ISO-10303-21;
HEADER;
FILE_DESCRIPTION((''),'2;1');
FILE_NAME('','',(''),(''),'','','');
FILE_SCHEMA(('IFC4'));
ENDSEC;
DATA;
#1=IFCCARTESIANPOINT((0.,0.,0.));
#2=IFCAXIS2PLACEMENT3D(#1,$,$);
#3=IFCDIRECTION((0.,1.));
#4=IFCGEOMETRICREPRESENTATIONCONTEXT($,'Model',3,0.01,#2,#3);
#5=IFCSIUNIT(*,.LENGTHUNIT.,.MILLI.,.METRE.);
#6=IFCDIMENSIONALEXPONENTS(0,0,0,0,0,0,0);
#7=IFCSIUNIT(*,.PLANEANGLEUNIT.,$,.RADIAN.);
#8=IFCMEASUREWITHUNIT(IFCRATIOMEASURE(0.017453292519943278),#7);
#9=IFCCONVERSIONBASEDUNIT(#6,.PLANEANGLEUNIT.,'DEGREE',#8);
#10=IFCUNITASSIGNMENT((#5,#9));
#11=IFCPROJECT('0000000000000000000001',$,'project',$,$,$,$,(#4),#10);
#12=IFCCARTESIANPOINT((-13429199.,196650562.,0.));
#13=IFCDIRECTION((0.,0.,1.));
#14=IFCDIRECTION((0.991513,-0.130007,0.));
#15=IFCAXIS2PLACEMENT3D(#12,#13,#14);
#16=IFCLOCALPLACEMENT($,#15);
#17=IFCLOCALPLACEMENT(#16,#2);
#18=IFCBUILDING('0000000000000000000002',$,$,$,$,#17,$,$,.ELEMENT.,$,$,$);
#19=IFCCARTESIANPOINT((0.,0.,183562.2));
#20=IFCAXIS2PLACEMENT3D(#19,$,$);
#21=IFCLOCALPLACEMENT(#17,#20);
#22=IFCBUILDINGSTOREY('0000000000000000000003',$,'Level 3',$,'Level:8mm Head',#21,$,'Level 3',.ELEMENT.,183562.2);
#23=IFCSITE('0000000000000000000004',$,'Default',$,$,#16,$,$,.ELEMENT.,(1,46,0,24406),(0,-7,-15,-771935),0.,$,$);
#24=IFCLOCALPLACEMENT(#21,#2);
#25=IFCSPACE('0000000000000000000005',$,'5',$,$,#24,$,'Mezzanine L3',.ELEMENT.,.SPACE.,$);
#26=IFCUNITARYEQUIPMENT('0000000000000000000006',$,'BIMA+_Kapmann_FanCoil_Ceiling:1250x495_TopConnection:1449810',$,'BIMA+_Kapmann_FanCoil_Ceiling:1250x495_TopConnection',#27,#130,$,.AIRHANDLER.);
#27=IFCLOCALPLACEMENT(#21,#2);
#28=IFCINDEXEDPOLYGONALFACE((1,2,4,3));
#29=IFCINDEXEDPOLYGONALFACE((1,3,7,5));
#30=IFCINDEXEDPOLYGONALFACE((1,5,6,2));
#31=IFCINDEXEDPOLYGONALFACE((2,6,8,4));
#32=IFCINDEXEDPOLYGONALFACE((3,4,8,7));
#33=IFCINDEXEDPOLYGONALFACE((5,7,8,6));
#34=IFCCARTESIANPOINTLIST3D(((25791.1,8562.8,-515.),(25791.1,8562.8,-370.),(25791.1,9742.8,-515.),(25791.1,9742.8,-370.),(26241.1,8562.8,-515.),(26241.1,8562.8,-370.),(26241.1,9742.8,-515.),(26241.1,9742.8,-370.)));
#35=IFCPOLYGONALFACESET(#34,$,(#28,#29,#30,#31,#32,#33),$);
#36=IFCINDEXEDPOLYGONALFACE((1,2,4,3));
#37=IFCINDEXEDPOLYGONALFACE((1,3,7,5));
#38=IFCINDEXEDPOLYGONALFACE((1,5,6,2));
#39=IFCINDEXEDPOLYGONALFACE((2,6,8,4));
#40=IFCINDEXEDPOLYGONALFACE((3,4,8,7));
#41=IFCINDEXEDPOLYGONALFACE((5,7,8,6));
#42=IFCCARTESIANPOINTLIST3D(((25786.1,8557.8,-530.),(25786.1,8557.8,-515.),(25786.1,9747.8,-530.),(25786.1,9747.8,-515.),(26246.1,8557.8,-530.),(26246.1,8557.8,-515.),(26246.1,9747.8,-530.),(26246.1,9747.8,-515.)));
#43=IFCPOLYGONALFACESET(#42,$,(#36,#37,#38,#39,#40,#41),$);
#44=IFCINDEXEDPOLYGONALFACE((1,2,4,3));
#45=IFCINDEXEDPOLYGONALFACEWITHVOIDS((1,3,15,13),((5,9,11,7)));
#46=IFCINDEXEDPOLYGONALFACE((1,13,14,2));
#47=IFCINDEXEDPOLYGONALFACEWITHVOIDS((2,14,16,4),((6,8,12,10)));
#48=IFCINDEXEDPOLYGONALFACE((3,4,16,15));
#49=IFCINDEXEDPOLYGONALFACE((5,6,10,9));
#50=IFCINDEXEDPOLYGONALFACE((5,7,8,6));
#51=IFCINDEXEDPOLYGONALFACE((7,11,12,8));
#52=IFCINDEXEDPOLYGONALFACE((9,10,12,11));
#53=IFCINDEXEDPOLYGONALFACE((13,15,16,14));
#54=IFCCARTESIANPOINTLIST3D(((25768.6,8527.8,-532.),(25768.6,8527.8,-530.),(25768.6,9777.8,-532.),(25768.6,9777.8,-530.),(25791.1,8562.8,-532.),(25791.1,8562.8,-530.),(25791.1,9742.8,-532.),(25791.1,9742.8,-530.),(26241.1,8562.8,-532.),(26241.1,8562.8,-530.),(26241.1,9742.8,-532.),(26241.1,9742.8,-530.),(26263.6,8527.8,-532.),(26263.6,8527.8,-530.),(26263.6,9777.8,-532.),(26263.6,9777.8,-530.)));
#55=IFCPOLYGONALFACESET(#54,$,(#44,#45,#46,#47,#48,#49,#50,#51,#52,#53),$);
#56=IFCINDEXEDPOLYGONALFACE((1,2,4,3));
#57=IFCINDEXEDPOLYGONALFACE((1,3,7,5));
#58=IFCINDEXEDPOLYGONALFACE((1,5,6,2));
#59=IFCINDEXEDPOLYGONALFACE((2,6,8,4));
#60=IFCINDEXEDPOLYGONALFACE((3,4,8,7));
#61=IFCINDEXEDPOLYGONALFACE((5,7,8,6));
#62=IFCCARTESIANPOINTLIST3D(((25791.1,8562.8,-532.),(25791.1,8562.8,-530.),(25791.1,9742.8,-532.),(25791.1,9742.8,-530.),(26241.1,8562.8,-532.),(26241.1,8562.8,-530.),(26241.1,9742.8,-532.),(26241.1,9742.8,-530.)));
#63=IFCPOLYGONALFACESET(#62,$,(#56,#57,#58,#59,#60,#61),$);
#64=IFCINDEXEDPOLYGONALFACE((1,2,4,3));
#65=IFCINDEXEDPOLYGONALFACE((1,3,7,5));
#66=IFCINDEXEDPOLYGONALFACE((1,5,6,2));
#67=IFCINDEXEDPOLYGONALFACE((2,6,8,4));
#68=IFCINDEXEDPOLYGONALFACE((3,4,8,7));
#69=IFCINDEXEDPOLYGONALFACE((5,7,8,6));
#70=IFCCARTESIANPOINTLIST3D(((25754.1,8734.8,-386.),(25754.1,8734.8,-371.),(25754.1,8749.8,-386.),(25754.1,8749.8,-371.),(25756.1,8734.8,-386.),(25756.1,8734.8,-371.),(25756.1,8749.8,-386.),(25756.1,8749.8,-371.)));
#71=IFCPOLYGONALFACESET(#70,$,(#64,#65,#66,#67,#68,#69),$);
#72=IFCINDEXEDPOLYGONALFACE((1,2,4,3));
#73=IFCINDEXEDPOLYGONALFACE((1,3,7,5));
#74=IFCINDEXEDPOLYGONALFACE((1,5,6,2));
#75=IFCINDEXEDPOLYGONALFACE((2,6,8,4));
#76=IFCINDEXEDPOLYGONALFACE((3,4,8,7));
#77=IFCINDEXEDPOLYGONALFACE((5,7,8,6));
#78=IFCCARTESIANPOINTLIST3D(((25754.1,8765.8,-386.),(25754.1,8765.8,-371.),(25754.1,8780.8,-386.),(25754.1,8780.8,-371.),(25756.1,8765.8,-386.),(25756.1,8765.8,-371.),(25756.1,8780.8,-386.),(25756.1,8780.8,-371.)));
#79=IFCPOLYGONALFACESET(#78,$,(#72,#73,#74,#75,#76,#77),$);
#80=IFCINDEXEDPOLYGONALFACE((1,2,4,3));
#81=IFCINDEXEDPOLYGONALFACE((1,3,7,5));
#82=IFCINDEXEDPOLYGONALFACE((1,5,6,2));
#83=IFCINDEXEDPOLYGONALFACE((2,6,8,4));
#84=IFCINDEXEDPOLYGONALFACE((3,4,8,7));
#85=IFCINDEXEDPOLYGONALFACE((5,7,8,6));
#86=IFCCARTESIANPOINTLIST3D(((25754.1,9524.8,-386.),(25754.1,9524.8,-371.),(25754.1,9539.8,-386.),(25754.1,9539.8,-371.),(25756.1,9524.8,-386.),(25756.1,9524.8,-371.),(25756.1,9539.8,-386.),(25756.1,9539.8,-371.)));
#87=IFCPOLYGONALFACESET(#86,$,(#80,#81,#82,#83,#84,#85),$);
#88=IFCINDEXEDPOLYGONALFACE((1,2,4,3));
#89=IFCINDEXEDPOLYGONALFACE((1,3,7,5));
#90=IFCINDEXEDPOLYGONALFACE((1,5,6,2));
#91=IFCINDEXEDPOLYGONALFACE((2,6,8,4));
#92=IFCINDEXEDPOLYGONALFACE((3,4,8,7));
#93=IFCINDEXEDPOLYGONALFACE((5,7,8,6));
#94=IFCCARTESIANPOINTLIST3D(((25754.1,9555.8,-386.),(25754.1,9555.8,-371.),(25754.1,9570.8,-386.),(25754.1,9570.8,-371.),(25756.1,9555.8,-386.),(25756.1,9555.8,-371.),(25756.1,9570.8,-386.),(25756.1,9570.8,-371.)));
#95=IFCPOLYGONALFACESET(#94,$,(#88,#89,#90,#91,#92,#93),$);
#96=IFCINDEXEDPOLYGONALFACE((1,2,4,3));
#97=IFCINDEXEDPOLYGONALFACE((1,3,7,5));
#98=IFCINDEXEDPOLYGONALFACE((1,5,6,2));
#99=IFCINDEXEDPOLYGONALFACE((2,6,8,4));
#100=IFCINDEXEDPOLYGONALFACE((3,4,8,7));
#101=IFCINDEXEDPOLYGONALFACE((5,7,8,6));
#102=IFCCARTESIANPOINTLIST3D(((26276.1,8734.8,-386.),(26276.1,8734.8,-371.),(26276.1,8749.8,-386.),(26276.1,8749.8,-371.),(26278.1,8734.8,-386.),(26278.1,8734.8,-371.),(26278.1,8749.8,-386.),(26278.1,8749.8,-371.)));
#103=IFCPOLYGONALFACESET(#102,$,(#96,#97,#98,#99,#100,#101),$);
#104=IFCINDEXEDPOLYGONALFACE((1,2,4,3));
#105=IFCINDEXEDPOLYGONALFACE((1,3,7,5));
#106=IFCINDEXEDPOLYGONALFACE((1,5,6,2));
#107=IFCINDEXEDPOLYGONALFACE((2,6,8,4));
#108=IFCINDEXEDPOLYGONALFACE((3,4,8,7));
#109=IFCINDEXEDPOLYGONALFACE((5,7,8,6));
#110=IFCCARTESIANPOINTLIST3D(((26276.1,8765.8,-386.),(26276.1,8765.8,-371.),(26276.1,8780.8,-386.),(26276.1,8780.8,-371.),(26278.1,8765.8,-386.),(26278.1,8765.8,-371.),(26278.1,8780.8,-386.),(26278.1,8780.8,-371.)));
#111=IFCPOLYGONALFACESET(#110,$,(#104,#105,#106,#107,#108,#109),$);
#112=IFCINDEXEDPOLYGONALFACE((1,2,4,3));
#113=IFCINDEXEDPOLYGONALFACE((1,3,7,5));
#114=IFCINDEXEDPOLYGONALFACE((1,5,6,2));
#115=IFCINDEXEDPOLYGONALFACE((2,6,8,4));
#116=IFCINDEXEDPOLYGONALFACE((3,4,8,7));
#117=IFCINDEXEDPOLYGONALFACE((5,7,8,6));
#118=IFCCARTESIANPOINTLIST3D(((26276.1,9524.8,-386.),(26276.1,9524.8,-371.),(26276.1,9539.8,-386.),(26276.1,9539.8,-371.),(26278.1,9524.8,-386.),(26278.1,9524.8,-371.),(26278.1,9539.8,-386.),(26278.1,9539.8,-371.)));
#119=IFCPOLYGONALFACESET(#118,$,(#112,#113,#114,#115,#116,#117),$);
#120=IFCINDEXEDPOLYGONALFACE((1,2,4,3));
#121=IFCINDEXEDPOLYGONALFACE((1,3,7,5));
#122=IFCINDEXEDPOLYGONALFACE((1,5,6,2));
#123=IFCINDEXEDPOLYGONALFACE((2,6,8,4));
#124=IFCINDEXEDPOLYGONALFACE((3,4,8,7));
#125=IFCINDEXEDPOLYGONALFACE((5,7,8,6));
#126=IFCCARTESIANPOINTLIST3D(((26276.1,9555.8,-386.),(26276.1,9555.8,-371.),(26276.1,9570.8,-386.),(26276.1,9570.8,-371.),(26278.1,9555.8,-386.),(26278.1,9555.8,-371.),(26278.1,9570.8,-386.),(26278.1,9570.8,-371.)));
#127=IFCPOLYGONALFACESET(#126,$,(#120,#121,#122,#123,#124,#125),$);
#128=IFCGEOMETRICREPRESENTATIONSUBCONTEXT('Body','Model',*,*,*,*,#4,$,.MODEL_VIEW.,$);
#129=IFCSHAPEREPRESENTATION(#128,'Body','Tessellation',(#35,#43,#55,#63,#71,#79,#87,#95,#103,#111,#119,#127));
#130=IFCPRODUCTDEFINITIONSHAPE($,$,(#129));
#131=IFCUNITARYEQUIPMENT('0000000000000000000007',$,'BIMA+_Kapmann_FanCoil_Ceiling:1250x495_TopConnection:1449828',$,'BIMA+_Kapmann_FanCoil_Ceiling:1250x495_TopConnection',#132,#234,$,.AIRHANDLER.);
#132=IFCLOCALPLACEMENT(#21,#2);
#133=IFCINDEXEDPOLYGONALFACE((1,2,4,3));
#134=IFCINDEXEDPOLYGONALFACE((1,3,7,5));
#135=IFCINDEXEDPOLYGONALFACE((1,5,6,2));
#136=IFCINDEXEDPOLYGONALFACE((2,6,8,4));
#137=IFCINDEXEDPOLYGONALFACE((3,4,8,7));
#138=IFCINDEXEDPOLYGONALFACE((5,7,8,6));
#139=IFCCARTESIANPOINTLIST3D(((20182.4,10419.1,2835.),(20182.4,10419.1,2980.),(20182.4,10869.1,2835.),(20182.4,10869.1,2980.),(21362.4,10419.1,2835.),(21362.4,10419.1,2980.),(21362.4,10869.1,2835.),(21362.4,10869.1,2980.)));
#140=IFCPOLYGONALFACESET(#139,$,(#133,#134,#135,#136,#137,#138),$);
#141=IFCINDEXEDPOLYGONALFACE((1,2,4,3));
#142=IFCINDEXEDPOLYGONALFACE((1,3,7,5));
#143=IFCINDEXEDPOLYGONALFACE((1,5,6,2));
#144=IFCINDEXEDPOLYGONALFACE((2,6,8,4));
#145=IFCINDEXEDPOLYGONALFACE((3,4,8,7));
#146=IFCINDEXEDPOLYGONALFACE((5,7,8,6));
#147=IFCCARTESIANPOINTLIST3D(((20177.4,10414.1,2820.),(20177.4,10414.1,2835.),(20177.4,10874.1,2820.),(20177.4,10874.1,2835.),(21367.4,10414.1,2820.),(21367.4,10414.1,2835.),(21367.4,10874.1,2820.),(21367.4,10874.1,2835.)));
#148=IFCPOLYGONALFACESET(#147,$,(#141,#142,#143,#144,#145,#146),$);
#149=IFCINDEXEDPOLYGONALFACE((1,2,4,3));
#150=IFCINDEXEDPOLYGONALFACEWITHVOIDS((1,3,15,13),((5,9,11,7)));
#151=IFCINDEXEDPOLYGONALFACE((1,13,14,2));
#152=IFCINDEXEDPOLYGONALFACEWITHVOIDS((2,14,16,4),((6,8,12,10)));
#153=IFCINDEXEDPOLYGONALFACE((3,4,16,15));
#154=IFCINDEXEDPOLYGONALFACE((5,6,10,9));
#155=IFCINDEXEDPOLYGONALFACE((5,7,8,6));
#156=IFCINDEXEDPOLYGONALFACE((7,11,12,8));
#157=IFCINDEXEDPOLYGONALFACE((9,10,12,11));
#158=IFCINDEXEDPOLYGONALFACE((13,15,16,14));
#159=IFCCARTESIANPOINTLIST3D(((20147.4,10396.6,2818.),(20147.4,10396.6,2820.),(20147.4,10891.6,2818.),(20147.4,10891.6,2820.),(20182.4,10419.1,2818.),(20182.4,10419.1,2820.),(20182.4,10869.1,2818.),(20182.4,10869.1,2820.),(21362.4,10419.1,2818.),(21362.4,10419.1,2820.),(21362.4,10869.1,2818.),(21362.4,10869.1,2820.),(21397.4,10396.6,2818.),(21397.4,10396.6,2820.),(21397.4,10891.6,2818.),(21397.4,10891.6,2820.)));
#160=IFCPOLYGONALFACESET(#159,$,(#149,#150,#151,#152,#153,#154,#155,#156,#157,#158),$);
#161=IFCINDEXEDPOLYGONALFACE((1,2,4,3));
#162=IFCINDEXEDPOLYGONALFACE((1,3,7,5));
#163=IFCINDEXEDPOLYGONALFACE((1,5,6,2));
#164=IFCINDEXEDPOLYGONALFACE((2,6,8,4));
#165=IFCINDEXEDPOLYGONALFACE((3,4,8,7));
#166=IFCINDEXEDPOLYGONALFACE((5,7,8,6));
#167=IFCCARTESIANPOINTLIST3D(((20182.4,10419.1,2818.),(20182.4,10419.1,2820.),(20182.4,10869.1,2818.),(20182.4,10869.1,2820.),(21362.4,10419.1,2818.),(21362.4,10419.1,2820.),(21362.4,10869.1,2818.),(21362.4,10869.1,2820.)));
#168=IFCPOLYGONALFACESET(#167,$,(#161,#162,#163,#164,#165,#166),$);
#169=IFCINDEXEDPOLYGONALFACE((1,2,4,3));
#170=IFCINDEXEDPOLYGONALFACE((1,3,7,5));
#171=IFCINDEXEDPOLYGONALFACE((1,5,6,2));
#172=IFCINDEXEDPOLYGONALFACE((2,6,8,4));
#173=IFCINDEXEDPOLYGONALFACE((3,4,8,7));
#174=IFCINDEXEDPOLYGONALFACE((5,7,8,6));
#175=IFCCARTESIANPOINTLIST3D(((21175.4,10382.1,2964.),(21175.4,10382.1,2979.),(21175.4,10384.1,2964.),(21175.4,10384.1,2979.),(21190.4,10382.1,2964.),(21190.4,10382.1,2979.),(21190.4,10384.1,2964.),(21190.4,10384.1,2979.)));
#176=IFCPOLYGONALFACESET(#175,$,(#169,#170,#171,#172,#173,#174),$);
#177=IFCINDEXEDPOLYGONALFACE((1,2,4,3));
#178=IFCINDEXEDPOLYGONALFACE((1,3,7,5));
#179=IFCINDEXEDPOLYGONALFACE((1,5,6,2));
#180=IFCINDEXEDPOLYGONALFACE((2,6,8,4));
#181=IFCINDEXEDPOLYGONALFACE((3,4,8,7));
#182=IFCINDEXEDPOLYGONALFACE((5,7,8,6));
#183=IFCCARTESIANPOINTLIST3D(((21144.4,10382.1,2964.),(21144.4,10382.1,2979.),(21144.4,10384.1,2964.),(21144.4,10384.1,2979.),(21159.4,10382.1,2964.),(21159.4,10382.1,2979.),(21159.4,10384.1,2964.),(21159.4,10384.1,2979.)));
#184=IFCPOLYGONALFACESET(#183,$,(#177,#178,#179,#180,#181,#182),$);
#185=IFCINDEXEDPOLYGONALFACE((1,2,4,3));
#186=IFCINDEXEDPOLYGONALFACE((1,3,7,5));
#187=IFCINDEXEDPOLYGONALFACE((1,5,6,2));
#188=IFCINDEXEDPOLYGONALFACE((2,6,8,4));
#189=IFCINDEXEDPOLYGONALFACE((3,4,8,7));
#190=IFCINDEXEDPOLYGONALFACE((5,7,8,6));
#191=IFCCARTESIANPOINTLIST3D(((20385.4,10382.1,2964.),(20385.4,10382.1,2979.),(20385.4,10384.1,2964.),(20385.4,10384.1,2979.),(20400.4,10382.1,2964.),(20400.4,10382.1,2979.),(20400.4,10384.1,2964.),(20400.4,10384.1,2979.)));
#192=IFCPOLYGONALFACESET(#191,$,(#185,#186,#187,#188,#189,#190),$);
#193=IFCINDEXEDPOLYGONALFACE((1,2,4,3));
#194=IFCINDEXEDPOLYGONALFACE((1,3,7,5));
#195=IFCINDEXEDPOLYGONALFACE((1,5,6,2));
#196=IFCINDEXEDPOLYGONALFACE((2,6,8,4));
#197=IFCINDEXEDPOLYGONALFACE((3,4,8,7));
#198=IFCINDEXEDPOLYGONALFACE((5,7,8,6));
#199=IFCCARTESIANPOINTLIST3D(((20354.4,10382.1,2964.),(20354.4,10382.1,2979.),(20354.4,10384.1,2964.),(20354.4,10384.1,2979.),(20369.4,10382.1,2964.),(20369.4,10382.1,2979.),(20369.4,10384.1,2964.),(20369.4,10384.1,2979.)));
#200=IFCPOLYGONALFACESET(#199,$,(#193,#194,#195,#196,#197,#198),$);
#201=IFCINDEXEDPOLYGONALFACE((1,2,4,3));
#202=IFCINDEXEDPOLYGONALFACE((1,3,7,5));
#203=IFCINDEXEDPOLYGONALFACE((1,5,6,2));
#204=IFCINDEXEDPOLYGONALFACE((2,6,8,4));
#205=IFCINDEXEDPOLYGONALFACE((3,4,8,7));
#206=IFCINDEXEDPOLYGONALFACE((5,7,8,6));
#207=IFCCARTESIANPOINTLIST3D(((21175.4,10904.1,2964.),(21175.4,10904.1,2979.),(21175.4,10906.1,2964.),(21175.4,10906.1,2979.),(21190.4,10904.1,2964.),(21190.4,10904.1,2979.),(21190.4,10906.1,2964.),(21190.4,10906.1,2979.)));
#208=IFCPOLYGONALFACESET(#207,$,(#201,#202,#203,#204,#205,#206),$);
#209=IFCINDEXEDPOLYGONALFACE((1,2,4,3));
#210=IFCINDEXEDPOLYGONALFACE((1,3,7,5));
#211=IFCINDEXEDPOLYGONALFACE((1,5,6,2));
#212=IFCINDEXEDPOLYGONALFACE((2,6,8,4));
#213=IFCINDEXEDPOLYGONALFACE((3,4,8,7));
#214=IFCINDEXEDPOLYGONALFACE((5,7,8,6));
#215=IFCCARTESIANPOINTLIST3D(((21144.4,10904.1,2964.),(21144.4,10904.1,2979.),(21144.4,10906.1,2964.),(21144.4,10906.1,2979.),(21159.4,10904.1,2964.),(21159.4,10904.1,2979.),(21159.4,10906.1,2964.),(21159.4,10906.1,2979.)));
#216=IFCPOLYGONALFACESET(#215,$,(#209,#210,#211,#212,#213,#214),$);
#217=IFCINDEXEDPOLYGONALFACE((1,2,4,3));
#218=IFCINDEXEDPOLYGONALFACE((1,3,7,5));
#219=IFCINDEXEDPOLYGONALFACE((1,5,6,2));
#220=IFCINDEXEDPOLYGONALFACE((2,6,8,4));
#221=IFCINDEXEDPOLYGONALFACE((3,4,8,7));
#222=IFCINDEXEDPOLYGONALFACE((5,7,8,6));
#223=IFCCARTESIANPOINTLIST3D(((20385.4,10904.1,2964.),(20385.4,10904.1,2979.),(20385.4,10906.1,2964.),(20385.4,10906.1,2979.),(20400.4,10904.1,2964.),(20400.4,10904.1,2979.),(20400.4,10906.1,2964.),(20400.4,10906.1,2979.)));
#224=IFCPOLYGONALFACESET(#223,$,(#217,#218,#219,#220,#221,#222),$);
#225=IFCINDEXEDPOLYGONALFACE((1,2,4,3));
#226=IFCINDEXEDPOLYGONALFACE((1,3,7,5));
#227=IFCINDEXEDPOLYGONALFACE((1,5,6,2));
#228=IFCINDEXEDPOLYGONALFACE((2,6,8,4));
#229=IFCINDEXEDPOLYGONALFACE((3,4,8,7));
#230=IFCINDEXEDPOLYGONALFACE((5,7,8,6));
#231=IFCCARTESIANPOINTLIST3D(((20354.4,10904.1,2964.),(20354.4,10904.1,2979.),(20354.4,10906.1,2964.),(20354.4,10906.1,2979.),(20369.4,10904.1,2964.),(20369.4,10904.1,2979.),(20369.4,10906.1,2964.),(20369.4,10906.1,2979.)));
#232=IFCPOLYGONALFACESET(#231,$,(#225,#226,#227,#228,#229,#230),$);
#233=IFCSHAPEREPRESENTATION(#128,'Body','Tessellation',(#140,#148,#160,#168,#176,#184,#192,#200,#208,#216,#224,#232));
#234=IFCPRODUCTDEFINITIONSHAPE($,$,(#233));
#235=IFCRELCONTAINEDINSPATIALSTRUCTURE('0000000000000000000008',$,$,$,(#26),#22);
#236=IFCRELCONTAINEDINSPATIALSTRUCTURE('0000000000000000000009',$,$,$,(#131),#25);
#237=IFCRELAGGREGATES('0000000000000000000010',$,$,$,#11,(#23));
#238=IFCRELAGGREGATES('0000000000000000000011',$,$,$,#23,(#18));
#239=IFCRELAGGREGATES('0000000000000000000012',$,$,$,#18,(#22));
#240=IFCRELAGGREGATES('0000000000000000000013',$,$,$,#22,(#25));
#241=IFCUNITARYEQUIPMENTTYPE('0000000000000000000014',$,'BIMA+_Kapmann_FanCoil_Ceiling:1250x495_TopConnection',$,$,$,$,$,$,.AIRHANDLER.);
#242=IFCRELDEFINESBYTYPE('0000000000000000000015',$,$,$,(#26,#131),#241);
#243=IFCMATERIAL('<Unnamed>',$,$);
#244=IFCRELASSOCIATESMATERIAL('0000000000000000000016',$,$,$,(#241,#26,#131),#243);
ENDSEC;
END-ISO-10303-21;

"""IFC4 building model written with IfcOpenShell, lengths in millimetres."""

from ifc_helpers import new_model, entity, si_unit, converted_unit, direction, frame, origin, place, context, subcontext, project, spatial, indexed_curve, outline, extrude, source, transform, mapped, material, type_object, type_shapes, element, save


model = new_model("IFC4")

# Units and contexts
model_context = context("Model", 3, precision=0.01, world=origin(), true_north=direction((0.0, 1.0)))
body_context = subcontext(model_context, "Body", "Model", "MODEL_VIEW")
ifc_project = project(units=[si_unit("LENGTHUNIT", "METRE", prefix="MILLI"), converted_unit("PLANEANGLEUNIT", "DEGREE", entity("IfcRatioMeasure", 0.017453292519943278), si_unit("PLANEANGLEUNIT", "RADIAN"), dimensions=[0, 0, 0, 0, 0, 0, 0])], contexts=[model_context])

# Site, building, storey
site_placement = place(None, frame((-13429199.0, 196650562.0, 0.0), z_axis=(0.0, 0.0, 1.0), x_axis=(0.991513, -0.130007, 0.0)))
site = spatial("IfcSite", under=ifc_project, at=site_placement, Name="Default", CompositionType="ELEMENT", RefLatitude=(1, 46, 0, 24406), RefLongitude=(0, -7, -15, -771935), RefElevation=0.0)
building_placement = place(site_placement, origin())
building = spatial("IfcBuilding", under=site, at=building_placement, CompositionType="ELEMENT")
storey_placement = place(building_placement, frame((0.0, 0.0, 183562.2)))
storey = spatial("IfcBuildingStorey", under=building, at=storey_placement, Name="Level 3", ObjectType="Level:8mm Head", LongName="Level 3", CompositionType="ELEMENT", Elevation=183562.2)

# Unitary equipment
ifc_material_1 = material(Name="<Unnamed>")
unitary_equipment_type = type_object("IfcUnitaryEquipmentType", Name="BIMA+_Kapmann_FanCoil_Ceiling:1250x495_TopConnection", PredefinedType="AIRHANDLER", material=ifc_material_1)
shared_shape = source(origin(), body_context, "Body", "SweptSolid", [
    extrude(outline(indexed_curve([(-590.0, -225.0), (590.0, -225.0), (590.0, 225.0), (-590.0, 225.0), (-590.0, -225.0)], self_intersect=False)), frame((0.0, 0.0, 15.0)), (0.0, 0.0, 1.0), 145.0),
    extrude(outline(indexed_curve([(-595.0, -230.0), (595.0, -230.0), (595.0, 230.0), (-595.0, 230.0), (-595.0, -230.0)], self_intersect=False)), frame((0.0, 0.0, 0.0), z_axis=(0.0, 0.0, 1.0), x_axis=(-1.0, 0.0, 0.0)), (0.0, 0.0, 1.0), 15.0),
    extrude(outline(indexed_curve([(-625.0, -247.5), (625.0, -247.5), (625.0, 247.5), (-625.0, 247.5), (-625.0, -247.5)], self_intersect=False), holes=[indexed_curve([(-590.0, -225.0), (-590.0, 225.0), (590.0, 225.0), (590.0, -225.0), (-590.0, -225.0)], self_intersect=False)]), frame((0.0, 0.0, -2.0), z_axis=(0.0, 0.0, 1.0), x_axis=(-1.0, 0.0, 0.0)), (0.0, 0.0, 1.0), 2.0),
    extrude(outline(indexed_curve([(-590.0, -225.0), (590.0, -225.0), (590.0, 225.0), (-590.0, 225.0), (-590.0, -225.0)], self_intersect=False)), frame((0.0, 0.0, -2.0), z_axis=(0.0, 0.0, 1.0), x_axis=(-1.0, 0.0, 0.0)), (0.0, 0.0, 1.0), 2.0),
    extrude(outline(indexed_curve([(-1.0, -7.5), (1.0, -7.5), (1.0, 7.5), (-1.0, 7.5), (-1.0, -7.5)], self_intersect=False)), frame((-410.5, 261.0, 144.0), z_axis=(0.0, 0.0, 1.0), x_axis=(0.0, -1.0, 0.0)), (0.0, 0.0, 1.0), 15.0),
    extrude(outline(indexed_curve([(-1.0, -7.5), (1.0, -7.5), (1.0, 7.5), (-1.0, 7.5), (-1.0, -7.5)], self_intersect=False)), frame((-379.5, 261.0, 144.0), z_axis=(0.0, 0.0, 1.0), x_axis=(0.0, -1.0, 0.0)), (0.0, 0.0, 1.0), 15.0),
    extrude(outline(indexed_curve([(-1.0, -7.5), (1.0, -7.5), (1.0, 7.5), (-1.0, 7.5), (-1.0, -7.5)], self_intersect=False)), frame((379.5, 261.0, 144.0), z_axis=(0.0, 0.0, 1.0), x_axis=(0.0, -1.0, 0.0)), (0.0, 0.0, 1.0), 15.0),
    extrude(outline(indexed_curve([(-1.0, -7.5), (1.0, -7.5), (1.0, 7.5), (-1.0, 7.5), (-1.0, -7.5)], self_intersect=False)), frame((410.5, 261.0, 144.0), z_axis=(0.0, 0.0, 1.0), x_axis=(0.0, -1.0, 0.0)), (0.0, 0.0, 1.0), 15.0),
    extrude(outline(indexed_curve([(-1.0, -7.5), (1.0, -7.5), (1.0, 7.5), (-1.0, 7.5), (-1.0, -7.5)], self_intersect=False)), frame((-410.5, -261.0, 144.0), z_axis=(0.0, 0.0, 1.0), x_axis=(0.0, -1.0, 0.0)), (0.0, 0.0, 1.0), 15.0),
    extrude(outline(indexed_curve([(-1.0, -7.5), (1.0, -7.5), (1.0, 7.5), (-1.0, 7.5), (-1.0, -7.5)], self_intersect=False)), frame((-379.5, -261.0, 144.0), z_axis=(0.0, 0.0, 1.0), x_axis=(0.0, -1.0, 0.0)), (0.0, 0.0, 1.0), 15.0),
    extrude(outline(indexed_curve([(-1.0, -7.5), (1.0, -7.5), (1.0, 7.5), (-1.0, 7.5), (-1.0, -7.5)], self_intersect=False)), frame((379.5, -261.0, 144.0), z_axis=(0.0, 0.0, 1.0), x_axis=(0.0, -1.0, 0.0)), (0.0, 0.0, 1.0), 15.0),
    extrude(outline(indexed_curve([(-1.0, -7.5), (1.0, -7.5), (1.0, 7.5), (-1.0, 7.5), (-1.0, -7.5)], self_intersect=False)), frame((410.5, -261.0, 144.0), z_axis=(0.0, 0.0, 1.0), x_axis=(0.0, -1.0, 0.0)), (0.0, 0.0, 1.0), 15.0),
])
type_shapes(unitary_equipment_type, [shared_shape])
unitary_equipment_1_placement = place(storey_placement, frame((26016.1, 9152.8, -530.0), z_axis=(0.0, 0.0, 1.0), x_axis=(0.0, 1.0, 0.0)))
element("IfcUnitaryEquipment", 1, at=unitary_equipment_1_placement, inside=storey, type_object=unitary_equipment_type, material=ifc_material_1, Name="BIMA+_Kapmann_FanCoil_Ceiling:1250x495_TopConnection:1449810", ObjectType="BIMA+_Kapmann_FanCoil_Ceiling:1250x495_TopConnection", PredefinedType="AIRHANDLER", context=body_context, shape_type="MappedRepresentation", body=[
    mapped(shared_shape, transform((0.0, 0.0, 0.0), scale=1.0)),
])

# Shared definitions
space_placement = place(storey_placement, origin())
space = spatial("IfcSpace", under=storey, at=space_placement, Name="5", LongName="Mezzanine L3", CompositionType="ELEMENT", PredefinedType="SPACE")

# Unitary equipment
unitary_equipment_2_placement = place(space_placement, frame((20772.4, 10644.1, 2820.0), z_axis=(0.0, 0.0, 1.0), x_axis=(-1.0, 0.0, 0.0)))
element("IfcUnitaryEquipment", 2, at=unitary_equipment_2_placement, inside=space, type_object=unitary_equipment_type, material=ifc_material_1, Name="BIMA+_Kapmann_FanCoil_Ceiling:1250x495_TopConnection:1449828", ObjectType="BIMA+_Kapmann_FanCoil_Ceiling:1250x495_TopConnection", PredefinedType="AIRHANDLER", context=body_context, shape_type="MappedRepresentation", body=[
    mapped(shared_shape, transform((0.0, 0.0, 0.0), scale=1.0)),
])

save(model, "model.ifc")
